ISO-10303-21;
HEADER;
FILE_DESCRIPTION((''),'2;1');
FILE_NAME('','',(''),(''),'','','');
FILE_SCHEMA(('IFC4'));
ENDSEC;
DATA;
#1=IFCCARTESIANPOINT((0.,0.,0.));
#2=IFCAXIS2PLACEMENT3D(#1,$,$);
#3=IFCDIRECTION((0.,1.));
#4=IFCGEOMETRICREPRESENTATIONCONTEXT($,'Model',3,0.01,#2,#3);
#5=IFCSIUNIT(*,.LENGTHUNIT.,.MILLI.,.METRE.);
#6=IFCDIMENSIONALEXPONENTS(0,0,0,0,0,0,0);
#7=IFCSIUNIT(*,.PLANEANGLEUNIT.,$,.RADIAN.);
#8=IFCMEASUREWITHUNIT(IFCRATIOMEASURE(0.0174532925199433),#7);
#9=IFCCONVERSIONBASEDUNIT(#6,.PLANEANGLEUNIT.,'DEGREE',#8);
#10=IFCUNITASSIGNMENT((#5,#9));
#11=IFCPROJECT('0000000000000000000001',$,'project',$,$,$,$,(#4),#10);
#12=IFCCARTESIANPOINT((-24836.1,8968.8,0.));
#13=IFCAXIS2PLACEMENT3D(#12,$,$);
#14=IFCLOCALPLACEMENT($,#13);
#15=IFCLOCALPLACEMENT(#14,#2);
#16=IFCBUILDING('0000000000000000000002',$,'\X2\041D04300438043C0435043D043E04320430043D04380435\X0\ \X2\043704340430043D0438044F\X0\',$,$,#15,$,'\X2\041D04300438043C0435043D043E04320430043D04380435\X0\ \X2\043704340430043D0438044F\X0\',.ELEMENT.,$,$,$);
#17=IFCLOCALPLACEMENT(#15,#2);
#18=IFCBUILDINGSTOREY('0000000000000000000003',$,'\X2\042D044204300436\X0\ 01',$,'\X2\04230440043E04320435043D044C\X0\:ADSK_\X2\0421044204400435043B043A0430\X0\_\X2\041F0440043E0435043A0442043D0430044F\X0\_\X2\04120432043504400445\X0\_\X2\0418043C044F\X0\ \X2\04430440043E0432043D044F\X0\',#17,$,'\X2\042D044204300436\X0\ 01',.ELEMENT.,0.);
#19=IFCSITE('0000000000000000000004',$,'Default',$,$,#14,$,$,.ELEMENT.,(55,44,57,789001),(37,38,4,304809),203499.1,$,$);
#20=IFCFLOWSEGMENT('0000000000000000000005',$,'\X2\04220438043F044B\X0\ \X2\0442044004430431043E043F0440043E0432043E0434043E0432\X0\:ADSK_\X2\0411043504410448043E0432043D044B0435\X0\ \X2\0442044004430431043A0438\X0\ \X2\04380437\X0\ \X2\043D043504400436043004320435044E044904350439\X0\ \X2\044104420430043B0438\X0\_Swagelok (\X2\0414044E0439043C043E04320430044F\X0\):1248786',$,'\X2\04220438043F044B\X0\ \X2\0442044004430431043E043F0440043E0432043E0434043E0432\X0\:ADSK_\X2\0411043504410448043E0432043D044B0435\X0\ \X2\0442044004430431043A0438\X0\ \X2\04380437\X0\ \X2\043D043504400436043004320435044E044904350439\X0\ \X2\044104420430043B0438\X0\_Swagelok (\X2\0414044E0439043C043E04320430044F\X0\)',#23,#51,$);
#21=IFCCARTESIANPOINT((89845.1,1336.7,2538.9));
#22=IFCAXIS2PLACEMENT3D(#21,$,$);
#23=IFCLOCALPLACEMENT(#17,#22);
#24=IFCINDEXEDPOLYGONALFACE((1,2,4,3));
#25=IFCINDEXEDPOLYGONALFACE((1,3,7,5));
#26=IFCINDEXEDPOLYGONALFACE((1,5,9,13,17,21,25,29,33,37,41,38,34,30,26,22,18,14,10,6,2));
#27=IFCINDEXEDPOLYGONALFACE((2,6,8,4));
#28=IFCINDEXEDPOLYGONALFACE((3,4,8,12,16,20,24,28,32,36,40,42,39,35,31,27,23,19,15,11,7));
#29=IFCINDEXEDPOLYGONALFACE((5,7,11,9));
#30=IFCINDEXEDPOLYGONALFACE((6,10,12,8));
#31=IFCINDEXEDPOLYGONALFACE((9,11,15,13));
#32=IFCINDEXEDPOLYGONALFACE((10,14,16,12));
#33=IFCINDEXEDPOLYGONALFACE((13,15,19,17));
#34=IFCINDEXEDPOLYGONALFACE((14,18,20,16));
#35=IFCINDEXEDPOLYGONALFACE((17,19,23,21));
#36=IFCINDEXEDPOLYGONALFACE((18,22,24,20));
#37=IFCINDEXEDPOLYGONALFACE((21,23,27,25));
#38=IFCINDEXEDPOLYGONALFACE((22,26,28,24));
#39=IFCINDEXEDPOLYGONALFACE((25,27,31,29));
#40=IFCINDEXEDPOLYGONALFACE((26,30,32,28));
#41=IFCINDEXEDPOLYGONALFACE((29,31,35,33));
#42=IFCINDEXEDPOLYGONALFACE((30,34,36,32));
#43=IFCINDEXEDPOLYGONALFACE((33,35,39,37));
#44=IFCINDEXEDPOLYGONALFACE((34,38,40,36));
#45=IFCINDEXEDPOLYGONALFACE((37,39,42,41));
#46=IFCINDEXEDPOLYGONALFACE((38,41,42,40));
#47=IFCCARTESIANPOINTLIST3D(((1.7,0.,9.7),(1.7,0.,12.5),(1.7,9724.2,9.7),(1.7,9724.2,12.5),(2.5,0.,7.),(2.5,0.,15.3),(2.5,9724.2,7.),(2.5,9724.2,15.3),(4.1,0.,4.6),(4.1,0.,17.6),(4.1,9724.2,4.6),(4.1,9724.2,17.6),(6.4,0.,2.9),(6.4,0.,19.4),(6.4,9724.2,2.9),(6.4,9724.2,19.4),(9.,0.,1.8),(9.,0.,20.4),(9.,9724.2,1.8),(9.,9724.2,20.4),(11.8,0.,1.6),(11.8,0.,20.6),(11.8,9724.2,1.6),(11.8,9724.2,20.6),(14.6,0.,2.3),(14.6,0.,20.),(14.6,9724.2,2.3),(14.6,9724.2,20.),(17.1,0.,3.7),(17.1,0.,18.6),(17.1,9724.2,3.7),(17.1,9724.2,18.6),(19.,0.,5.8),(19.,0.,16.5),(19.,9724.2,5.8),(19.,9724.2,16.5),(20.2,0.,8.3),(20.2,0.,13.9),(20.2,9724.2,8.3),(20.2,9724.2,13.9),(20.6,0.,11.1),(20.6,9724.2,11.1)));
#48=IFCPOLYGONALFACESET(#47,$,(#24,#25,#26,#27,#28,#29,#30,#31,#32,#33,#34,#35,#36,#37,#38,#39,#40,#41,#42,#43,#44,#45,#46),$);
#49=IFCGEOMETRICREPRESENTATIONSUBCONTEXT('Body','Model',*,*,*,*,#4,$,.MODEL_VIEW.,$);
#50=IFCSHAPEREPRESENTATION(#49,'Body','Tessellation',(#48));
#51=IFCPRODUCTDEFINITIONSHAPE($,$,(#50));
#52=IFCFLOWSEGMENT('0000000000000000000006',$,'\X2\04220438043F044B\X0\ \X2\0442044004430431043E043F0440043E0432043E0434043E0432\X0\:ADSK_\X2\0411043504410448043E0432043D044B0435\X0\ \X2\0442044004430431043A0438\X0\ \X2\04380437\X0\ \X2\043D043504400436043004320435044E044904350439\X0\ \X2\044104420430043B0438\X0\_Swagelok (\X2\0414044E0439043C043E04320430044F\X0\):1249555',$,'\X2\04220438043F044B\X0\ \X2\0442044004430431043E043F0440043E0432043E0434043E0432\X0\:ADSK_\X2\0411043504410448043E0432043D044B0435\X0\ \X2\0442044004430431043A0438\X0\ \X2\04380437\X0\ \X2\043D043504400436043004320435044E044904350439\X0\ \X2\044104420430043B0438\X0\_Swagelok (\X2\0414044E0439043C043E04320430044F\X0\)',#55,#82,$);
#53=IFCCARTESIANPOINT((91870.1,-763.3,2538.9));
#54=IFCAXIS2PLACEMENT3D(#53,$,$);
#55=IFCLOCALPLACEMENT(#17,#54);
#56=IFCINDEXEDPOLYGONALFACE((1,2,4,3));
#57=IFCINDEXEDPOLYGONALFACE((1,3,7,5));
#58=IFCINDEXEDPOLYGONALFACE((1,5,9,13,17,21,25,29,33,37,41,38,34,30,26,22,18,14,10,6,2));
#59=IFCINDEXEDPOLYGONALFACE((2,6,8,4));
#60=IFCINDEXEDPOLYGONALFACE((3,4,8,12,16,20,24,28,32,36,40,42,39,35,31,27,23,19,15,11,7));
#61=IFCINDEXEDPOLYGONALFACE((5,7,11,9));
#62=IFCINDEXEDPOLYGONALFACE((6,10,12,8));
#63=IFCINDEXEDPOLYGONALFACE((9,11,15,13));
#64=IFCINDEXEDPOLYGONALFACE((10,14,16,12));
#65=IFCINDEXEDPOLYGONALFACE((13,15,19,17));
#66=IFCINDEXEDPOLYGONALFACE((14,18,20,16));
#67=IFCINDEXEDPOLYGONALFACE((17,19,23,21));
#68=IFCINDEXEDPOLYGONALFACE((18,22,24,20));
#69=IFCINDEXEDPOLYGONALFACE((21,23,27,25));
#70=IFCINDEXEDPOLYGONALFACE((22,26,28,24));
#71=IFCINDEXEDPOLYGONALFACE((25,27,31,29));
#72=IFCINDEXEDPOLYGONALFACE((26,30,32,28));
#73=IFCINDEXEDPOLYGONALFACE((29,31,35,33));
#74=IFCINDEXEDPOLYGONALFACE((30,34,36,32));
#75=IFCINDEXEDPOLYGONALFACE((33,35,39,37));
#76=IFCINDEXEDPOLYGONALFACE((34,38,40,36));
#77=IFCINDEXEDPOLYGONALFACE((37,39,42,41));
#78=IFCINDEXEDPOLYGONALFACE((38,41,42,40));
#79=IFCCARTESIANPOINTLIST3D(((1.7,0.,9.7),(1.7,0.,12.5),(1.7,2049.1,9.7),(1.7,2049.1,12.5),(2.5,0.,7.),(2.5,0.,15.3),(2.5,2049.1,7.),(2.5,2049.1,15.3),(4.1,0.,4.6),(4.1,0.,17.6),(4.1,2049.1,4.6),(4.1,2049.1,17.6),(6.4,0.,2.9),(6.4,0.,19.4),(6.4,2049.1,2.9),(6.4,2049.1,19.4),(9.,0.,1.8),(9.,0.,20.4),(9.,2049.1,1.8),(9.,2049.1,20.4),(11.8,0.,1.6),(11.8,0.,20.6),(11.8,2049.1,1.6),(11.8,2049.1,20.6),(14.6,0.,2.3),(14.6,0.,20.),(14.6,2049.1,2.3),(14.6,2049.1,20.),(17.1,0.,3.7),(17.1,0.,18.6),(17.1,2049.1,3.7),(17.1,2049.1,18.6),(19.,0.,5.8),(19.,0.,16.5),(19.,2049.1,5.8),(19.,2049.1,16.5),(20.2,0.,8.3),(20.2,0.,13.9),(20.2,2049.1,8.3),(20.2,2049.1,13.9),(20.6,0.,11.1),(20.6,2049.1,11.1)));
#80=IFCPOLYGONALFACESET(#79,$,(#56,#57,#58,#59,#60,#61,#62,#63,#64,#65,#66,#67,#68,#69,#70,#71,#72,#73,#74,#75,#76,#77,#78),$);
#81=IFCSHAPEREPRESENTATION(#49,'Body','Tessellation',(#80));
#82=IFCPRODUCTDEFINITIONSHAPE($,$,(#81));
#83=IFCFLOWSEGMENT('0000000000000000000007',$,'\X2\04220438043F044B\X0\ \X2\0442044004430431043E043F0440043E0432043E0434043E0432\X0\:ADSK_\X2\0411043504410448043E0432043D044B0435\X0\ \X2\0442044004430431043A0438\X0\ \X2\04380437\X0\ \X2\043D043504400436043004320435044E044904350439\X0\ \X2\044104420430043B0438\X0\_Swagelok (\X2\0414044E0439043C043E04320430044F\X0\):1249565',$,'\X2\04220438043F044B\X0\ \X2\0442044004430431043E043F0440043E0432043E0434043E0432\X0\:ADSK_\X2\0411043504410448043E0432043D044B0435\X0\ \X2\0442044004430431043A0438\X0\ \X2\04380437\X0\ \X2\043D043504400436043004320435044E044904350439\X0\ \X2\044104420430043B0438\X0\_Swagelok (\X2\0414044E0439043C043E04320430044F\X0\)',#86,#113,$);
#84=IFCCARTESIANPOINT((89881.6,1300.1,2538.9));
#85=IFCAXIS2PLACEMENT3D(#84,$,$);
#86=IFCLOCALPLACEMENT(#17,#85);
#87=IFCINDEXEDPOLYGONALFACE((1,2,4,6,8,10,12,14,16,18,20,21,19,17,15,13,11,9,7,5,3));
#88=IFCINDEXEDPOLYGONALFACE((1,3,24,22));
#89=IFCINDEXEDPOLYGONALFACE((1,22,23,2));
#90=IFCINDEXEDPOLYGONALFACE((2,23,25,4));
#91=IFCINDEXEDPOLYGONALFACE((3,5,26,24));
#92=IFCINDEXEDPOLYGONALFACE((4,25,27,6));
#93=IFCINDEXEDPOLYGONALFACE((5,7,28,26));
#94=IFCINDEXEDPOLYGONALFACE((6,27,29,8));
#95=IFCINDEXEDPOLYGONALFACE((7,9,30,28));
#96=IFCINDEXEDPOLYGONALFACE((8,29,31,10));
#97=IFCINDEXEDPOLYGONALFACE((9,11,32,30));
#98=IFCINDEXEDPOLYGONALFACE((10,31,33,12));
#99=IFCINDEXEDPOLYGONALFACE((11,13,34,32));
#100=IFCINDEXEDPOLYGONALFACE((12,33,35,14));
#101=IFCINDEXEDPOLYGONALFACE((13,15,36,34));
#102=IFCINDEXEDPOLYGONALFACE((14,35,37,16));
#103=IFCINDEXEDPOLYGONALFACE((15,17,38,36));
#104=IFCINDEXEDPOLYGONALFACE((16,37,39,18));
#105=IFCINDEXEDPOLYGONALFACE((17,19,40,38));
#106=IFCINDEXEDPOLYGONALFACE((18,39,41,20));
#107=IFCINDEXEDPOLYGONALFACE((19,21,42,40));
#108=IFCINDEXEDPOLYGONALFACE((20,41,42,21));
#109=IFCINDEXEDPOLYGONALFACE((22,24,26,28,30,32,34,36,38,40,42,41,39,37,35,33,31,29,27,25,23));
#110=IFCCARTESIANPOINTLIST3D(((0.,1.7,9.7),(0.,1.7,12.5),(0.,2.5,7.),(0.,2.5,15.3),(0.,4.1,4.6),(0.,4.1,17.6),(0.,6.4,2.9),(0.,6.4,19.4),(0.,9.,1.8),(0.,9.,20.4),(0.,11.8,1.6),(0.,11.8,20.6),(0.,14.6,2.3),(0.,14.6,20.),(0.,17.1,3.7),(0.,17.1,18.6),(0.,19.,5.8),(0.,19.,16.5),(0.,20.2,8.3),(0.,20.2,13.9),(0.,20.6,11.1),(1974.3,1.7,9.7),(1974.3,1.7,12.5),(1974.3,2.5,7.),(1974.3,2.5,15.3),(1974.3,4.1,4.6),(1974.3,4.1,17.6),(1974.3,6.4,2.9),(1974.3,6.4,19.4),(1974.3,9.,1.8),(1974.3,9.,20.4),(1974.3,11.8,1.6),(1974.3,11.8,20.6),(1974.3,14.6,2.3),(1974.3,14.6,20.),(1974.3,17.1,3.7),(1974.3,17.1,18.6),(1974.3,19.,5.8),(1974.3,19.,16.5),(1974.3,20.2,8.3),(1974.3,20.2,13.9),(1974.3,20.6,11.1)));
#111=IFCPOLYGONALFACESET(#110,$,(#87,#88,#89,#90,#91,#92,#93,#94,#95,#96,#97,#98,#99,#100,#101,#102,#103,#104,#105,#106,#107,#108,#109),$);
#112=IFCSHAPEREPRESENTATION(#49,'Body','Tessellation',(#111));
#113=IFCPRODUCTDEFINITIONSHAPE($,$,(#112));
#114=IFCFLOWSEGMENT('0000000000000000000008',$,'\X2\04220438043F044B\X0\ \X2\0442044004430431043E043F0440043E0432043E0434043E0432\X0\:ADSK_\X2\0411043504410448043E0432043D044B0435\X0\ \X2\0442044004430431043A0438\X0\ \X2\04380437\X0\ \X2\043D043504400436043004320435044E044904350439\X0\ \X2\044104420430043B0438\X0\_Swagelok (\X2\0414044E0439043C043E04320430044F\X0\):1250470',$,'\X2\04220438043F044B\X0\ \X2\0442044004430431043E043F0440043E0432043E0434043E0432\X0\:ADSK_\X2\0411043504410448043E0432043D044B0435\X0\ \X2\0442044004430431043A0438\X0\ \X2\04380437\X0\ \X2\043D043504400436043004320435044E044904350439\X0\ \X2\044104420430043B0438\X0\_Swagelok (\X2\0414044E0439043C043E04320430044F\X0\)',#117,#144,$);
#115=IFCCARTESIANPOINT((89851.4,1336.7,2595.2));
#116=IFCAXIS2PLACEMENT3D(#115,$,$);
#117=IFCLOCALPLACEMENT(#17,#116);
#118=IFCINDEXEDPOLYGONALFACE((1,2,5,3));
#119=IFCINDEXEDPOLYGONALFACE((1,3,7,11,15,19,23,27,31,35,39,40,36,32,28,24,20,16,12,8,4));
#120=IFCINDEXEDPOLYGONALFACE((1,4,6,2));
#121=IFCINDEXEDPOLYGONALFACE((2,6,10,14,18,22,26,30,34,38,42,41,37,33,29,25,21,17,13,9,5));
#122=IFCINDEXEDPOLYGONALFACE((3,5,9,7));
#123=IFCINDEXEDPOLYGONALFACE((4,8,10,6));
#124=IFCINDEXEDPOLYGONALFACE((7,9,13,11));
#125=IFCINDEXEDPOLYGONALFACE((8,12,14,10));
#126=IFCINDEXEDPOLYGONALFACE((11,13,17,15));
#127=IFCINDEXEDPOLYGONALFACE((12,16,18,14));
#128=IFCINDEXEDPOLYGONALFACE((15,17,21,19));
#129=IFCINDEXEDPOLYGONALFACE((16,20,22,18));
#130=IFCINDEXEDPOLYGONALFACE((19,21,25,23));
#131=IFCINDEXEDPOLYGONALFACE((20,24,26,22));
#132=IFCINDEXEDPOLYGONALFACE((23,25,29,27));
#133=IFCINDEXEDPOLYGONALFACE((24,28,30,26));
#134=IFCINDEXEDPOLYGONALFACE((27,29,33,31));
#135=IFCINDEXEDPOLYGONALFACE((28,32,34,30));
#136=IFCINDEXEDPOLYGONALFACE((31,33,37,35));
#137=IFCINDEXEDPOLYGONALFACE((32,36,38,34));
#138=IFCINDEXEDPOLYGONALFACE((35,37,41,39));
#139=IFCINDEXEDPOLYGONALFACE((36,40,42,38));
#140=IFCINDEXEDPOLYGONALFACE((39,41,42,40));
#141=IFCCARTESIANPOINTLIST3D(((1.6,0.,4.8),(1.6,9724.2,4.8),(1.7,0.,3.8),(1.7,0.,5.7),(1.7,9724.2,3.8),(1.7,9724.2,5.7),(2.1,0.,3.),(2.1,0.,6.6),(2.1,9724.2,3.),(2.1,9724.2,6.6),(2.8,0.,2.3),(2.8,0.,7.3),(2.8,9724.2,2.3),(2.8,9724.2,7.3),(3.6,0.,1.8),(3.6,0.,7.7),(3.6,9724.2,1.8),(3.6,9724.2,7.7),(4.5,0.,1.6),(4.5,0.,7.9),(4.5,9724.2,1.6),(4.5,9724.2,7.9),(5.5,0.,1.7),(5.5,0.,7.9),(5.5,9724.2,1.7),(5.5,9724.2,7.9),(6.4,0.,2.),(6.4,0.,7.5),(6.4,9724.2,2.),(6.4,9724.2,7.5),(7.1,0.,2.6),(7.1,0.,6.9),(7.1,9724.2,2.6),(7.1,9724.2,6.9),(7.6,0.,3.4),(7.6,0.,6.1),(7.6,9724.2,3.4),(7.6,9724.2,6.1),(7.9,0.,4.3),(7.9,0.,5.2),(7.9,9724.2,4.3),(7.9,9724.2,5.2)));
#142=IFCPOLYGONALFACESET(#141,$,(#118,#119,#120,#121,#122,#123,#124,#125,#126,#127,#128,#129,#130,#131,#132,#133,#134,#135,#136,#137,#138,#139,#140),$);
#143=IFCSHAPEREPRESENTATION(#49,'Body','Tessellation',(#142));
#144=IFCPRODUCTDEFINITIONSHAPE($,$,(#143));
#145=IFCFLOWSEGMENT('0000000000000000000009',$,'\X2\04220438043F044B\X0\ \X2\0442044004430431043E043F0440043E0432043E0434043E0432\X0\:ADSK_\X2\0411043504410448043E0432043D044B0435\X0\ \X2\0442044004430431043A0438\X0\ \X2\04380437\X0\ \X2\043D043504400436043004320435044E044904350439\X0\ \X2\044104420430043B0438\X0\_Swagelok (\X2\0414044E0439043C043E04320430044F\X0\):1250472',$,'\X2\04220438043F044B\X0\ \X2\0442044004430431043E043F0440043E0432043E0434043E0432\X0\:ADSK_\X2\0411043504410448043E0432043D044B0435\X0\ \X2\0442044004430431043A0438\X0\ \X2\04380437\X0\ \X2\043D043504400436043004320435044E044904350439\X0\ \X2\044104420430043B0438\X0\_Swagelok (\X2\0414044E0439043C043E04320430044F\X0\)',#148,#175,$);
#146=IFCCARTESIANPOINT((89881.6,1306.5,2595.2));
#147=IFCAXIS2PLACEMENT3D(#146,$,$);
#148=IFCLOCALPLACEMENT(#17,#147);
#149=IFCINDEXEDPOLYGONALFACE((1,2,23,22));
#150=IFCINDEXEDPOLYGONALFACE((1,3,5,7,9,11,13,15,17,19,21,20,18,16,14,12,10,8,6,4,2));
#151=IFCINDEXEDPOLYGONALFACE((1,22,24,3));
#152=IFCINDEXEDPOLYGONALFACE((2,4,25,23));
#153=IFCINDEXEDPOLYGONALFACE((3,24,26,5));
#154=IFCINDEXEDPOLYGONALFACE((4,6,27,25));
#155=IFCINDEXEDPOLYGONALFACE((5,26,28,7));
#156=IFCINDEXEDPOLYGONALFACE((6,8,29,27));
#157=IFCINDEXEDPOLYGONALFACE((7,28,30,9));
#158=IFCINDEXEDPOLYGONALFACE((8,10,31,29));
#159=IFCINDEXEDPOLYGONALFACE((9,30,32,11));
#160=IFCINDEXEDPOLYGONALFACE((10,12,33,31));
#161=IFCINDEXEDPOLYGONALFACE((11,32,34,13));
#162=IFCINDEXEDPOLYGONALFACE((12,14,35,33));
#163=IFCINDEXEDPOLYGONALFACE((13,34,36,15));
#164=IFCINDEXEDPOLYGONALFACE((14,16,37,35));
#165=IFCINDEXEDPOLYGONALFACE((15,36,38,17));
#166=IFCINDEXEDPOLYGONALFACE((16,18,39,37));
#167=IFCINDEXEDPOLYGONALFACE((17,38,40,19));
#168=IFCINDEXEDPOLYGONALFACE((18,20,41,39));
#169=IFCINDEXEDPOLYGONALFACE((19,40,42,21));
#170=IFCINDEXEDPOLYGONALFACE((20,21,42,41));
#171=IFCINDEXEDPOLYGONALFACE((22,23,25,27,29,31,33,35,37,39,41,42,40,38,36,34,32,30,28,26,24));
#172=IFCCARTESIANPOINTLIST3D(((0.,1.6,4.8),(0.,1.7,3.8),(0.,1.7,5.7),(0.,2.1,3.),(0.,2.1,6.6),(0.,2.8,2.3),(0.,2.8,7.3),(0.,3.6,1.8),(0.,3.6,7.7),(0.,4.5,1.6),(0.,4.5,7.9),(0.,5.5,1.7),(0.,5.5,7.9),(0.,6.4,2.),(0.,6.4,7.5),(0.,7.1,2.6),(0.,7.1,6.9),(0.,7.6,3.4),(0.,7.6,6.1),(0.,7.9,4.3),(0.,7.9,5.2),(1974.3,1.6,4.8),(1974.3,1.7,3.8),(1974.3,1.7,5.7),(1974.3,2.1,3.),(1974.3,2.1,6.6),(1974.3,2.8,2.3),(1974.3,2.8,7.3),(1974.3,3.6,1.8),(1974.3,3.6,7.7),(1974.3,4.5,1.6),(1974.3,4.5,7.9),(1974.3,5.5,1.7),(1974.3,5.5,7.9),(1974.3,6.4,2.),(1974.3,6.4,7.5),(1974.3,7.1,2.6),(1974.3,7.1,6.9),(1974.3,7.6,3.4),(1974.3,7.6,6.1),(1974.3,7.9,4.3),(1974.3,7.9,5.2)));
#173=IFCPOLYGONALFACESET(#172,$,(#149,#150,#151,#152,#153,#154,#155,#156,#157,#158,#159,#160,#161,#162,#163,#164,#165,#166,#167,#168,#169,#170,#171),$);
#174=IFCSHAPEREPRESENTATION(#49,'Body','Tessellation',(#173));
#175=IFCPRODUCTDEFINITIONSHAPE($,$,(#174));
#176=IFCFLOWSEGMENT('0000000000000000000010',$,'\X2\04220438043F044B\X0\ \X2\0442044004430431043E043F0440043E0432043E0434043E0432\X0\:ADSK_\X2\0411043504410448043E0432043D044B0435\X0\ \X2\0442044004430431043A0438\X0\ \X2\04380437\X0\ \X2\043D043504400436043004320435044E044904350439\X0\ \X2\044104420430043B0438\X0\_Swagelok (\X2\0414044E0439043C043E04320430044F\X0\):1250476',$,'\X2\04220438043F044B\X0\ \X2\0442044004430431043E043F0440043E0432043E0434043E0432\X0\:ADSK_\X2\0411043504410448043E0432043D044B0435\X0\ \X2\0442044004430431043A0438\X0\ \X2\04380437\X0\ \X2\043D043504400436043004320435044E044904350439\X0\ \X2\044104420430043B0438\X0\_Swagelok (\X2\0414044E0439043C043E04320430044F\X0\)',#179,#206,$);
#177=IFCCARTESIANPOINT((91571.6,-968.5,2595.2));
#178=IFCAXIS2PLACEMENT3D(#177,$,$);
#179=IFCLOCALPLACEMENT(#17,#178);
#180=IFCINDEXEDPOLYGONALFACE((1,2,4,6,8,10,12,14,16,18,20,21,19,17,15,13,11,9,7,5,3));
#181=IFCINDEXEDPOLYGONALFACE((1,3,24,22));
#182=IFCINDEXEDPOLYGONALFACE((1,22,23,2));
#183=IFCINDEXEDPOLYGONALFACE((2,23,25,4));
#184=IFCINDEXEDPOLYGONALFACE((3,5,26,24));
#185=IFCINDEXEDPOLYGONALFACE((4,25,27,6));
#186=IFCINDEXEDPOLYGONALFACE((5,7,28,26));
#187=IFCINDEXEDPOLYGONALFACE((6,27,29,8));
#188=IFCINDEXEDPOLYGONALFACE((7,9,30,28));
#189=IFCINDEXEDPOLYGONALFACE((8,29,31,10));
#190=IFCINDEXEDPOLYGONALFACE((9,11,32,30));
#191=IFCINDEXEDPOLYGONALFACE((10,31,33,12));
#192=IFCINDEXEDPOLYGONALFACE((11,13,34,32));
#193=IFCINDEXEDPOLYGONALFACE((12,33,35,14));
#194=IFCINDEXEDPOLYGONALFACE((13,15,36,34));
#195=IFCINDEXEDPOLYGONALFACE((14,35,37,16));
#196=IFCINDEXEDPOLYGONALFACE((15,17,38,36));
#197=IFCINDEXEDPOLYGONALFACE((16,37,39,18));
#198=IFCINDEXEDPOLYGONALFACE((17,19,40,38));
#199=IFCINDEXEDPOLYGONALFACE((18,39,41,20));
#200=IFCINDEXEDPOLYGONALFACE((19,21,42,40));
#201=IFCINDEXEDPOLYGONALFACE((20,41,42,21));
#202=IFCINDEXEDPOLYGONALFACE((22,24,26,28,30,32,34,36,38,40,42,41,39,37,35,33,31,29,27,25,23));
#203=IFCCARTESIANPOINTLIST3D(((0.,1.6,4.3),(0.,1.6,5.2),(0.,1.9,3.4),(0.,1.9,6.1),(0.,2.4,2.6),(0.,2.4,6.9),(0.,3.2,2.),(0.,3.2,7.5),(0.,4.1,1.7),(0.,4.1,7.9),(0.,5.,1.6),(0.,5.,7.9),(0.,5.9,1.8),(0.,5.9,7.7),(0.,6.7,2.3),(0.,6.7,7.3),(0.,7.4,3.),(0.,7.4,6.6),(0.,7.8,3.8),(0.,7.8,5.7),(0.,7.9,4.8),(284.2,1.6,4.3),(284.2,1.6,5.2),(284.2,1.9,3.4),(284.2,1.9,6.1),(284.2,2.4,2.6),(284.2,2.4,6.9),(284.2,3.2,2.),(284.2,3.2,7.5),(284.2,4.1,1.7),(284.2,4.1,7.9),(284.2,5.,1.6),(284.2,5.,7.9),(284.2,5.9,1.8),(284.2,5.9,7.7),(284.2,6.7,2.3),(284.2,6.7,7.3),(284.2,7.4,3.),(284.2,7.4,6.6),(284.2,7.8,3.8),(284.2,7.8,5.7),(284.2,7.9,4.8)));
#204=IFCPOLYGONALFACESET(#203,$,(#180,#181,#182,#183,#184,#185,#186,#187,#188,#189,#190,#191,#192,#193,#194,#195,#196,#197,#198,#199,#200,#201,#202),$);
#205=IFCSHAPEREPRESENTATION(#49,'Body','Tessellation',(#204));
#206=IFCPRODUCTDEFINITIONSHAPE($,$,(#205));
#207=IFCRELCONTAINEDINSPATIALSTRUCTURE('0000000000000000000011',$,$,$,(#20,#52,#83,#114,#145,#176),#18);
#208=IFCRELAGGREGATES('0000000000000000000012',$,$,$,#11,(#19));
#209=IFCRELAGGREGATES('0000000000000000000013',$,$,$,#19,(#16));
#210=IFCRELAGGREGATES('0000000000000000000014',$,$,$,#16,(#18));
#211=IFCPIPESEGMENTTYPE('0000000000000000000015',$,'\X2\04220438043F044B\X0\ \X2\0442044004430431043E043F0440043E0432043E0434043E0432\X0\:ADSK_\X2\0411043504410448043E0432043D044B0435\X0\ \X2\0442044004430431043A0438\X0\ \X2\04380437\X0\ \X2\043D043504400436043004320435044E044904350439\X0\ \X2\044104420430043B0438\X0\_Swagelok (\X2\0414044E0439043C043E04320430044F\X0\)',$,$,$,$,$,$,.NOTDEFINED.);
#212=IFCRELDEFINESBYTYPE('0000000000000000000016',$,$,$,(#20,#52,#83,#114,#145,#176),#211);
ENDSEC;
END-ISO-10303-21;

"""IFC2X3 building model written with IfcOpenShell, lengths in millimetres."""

from ifc_helpers import new_model, entity, si_unit, converted_unit, direction, frame, origin, origin_2d_with_axis, place, context, subcontext, project, spatial, circle, extrude, type_object, element, save


model = new_model("IFC2X3")

# Units and contexts
model_context = context("Model", 3, precision=0.01, world=origin(), true_north=direction((0.0, 1.0)))
body_context = subcontext(model_context, "Body", "Model", "MODEL_VIEW")
ifc_project = project(units=[si_unit("LENGTHUNIT", "METRE", prefix="MILLI"), converted_unit("PLANEANGLEUNIT", "DEGREE", entity("IfcRatioMeasure", 0.0174532925199433), si_unit("PLANEANGLEUNIT", "RADIAN"), dimensions=[0, 0, 0, 0, 0, 0, 0])], contexts=[model_context])

# Site, building, storey
site_placement = place(None, frame((-24836.1, 8968.8, 0.0)))
site = spatial("IfcSite", under=ifc_project, at=site_placement, Name="Default", CompositionType="ELEMENT", RefLatitude=(55, 44, 57, 789001), RefLongitude=(37, 38, 4, 304809), RefElevation=203499.1)
building_placement = place(site_placement, origin())
building = spatial("IfcBuilding", under=site, at=building_placement, Name="Наименование здания", LongName="Наименование здания", CompositionType="ELEMENT")
storey_placement = place(building_placement, origin())
storey = spatial("IfcBuildingStorey", under=building, at=storey_placement, Name="Этаж 01", ObjectType="Уровень:ADSK_Стрелка_Проектная_Вверх_Имя уровня", LongName="Этаж 01", CompositionType="ELEMENT", Elevation=0.0)

# Flow segments
pipe_segment_type_1 = type_object("IfcPipeSegmentType", Name="Типы трубопроводов:ADSK_Бесшовные трубки из нержавеющей стали_Swagelok (Дюймовая)", PredefinedType="NOTDEFINED")
flow_segment_1_placement = place(storey_placement, frame((89845.1, 1336.7, 2538.9)))
element("IfcFlowSegment", 1, at=flow_segment_1_placement, inside=storey, type_object=pipe_segment_type_1, Name="Типы трубопроводов:ADSK_Бесшовные трубки из нержавеющей стали_Swagelok (Дюймовая):1248786", ObjectType="Типы трубопроводов:ADSK_Бесшовные трубки из нержавеющей стали_Swagelok (Дюймовая)", context=body_context, shape_type="SweptSolid", body=[
    extrude(circle(Radius=9.5, at=origin_2d_with_axis()), frame((11.1, 0.0, 11.1), z_axis=(0.0, 1.0, 0.0), x_axis=(1.0, 0.0, 0.0)), (0.0, 0.0, 1.0), 9724.2),
])
flow_segment_2_placement = place(storey_placement, frame((91870.1, -763.3, 2538.9)))
element("IfcFlowSegment", 2, at=flow_segment_2_placement, inside=storey, type_object=pipe_segment_type_1, Name="Типы трубопроводов:ADSK_Бесшовные трубки из нержавеющей стали_Swagelok (Дюймовая):1249555", ObjectType="Типы трубопроводов:ADSK_Бесшовные трубки из нержавеющей стали_Swagelok (Дюймовая)", context=body_context, shape_type="SweptSolid", body=[
    extrude(circle(Radius=9.5, at=origin_2d_with_axis()), frame((11.1, 0.0, 11.1), z_axis=(0.0, 1.0, 0.0), x_axis=(1.0, 0.0, 0.0)), (0.0, 0.0, 1.0), 2049.1),
])
flow_segment_3_placement = place(storey_placement, frame((89881.6, 1300.1, 2538.9)))
element("IfcFlowSegment", 3, at=flow_segment_3_placement, inside=storey, type_object=pipe_segment_type_1, Name="Типы трубопроводов:ADSK_Бесшовные трубки из нержавеющей стали_Swagelok (Дюймовая):1249565", ObjectType="Типы трубопроводов:ADSK_Бесшовные трубки из нержавеющей стали_Swagelok (Дюймовая)", context=body_context, shape_type="SweptSolid", body=[
    extrude(circle(Radius=9.5, at=origin_2d_with_axis()), frame((0.0, 11.1, 11.1), z_axis=(1.0, 0.0, 0.0), x_axis=(0.0, 1.0, 0.0)), (0.0, 0.0, 1.0), 1974.3),
])
flow_segment_4_placement = place(storey_placement, frame((89851.4, 1336.7, 2595.2)))
element("IfcFlowSegment", 4, at=flow_segment_4_placement, inside=storey, type_object=pipe_segment_type_1, Name="Типы трубопроводов:ADSK_Бесшовные трубки из нержавеющей стали_Swagelok (Дюймовая):1250470", ObjectType="Типы трубопроводов:ADSK_Бесшовные трубки из нержавеющей стали_Swagelok (Дюймовая)", context=body_context, shape_type="SweptSolid", body=[
    extrude(circle(Radius=3.2, at=origin_2d_with_axis()), frame((4.8, 0.0, 4.8), z_axis=(0.0, 1.0, 0.0), x_axis=(-1.0, 0.0, 0.0)), (0.0, 0.0, 1.0), 9724.2),
])
flow_segment_5_placement = place(storey_placement, frame((89881.6, 1306.5, 2595.2)))
element("IfcFlowSegment", 5, at=flow_segment_5_placement, inside=storey, type_object=pipe_segment_type_1, Name="Типы трубопроводов:ADSK_Бесшовные трубки из нержавеющей стали_Swagelok (Дюймовая):1250472", ObjectType="Типы трубопроводов:ADSK_Бесшовные трубки из нержавеющей стали_Swagelok (Дюймовая)", context=body_context, shape_type="SweptSolid", body=[
    extrude(circle(Radius=3.2, at=origin_2d_with_axis()), frame((0.0, 4.8, 4.8), z_axis=(1.0, 0.0, 0.0), x_axis=(0.0, -1.0, 0.0)), (0.0, 0.0, 1.0), 1974.3),
])
flow_segment_6_placement = place(storey_placement, frame((91571.6, -968.5, 2595.2)))
element("IfcFlowSegment", 6, at=flow_segment_6_placement, inside=storey, type_object=pipe_segment_type_1, Name="Типы трубопроводов:ADSK_Бесшовные трубки из нержавеющей стали_Swagelok (Дюймовая):1250476", ObjectType="Типы трубопроводов:ADSK_Бесшовные трубки из нержавеющей стали_Swagelok (Дюймовая)", context=body_context, shape_type="SweptSolid", body=[
    extrude(circle(Radius=3.2, at=origin_2d_with_axis()), frame((0.0, 4.8, 4.8), z_axis=(1.0, 0.0, 0.0), x_axis=(0.0, 1.0, 0.0)), (0.0, 0.0, 1.0), 284.2),
])

save(model, "model.ifc")
